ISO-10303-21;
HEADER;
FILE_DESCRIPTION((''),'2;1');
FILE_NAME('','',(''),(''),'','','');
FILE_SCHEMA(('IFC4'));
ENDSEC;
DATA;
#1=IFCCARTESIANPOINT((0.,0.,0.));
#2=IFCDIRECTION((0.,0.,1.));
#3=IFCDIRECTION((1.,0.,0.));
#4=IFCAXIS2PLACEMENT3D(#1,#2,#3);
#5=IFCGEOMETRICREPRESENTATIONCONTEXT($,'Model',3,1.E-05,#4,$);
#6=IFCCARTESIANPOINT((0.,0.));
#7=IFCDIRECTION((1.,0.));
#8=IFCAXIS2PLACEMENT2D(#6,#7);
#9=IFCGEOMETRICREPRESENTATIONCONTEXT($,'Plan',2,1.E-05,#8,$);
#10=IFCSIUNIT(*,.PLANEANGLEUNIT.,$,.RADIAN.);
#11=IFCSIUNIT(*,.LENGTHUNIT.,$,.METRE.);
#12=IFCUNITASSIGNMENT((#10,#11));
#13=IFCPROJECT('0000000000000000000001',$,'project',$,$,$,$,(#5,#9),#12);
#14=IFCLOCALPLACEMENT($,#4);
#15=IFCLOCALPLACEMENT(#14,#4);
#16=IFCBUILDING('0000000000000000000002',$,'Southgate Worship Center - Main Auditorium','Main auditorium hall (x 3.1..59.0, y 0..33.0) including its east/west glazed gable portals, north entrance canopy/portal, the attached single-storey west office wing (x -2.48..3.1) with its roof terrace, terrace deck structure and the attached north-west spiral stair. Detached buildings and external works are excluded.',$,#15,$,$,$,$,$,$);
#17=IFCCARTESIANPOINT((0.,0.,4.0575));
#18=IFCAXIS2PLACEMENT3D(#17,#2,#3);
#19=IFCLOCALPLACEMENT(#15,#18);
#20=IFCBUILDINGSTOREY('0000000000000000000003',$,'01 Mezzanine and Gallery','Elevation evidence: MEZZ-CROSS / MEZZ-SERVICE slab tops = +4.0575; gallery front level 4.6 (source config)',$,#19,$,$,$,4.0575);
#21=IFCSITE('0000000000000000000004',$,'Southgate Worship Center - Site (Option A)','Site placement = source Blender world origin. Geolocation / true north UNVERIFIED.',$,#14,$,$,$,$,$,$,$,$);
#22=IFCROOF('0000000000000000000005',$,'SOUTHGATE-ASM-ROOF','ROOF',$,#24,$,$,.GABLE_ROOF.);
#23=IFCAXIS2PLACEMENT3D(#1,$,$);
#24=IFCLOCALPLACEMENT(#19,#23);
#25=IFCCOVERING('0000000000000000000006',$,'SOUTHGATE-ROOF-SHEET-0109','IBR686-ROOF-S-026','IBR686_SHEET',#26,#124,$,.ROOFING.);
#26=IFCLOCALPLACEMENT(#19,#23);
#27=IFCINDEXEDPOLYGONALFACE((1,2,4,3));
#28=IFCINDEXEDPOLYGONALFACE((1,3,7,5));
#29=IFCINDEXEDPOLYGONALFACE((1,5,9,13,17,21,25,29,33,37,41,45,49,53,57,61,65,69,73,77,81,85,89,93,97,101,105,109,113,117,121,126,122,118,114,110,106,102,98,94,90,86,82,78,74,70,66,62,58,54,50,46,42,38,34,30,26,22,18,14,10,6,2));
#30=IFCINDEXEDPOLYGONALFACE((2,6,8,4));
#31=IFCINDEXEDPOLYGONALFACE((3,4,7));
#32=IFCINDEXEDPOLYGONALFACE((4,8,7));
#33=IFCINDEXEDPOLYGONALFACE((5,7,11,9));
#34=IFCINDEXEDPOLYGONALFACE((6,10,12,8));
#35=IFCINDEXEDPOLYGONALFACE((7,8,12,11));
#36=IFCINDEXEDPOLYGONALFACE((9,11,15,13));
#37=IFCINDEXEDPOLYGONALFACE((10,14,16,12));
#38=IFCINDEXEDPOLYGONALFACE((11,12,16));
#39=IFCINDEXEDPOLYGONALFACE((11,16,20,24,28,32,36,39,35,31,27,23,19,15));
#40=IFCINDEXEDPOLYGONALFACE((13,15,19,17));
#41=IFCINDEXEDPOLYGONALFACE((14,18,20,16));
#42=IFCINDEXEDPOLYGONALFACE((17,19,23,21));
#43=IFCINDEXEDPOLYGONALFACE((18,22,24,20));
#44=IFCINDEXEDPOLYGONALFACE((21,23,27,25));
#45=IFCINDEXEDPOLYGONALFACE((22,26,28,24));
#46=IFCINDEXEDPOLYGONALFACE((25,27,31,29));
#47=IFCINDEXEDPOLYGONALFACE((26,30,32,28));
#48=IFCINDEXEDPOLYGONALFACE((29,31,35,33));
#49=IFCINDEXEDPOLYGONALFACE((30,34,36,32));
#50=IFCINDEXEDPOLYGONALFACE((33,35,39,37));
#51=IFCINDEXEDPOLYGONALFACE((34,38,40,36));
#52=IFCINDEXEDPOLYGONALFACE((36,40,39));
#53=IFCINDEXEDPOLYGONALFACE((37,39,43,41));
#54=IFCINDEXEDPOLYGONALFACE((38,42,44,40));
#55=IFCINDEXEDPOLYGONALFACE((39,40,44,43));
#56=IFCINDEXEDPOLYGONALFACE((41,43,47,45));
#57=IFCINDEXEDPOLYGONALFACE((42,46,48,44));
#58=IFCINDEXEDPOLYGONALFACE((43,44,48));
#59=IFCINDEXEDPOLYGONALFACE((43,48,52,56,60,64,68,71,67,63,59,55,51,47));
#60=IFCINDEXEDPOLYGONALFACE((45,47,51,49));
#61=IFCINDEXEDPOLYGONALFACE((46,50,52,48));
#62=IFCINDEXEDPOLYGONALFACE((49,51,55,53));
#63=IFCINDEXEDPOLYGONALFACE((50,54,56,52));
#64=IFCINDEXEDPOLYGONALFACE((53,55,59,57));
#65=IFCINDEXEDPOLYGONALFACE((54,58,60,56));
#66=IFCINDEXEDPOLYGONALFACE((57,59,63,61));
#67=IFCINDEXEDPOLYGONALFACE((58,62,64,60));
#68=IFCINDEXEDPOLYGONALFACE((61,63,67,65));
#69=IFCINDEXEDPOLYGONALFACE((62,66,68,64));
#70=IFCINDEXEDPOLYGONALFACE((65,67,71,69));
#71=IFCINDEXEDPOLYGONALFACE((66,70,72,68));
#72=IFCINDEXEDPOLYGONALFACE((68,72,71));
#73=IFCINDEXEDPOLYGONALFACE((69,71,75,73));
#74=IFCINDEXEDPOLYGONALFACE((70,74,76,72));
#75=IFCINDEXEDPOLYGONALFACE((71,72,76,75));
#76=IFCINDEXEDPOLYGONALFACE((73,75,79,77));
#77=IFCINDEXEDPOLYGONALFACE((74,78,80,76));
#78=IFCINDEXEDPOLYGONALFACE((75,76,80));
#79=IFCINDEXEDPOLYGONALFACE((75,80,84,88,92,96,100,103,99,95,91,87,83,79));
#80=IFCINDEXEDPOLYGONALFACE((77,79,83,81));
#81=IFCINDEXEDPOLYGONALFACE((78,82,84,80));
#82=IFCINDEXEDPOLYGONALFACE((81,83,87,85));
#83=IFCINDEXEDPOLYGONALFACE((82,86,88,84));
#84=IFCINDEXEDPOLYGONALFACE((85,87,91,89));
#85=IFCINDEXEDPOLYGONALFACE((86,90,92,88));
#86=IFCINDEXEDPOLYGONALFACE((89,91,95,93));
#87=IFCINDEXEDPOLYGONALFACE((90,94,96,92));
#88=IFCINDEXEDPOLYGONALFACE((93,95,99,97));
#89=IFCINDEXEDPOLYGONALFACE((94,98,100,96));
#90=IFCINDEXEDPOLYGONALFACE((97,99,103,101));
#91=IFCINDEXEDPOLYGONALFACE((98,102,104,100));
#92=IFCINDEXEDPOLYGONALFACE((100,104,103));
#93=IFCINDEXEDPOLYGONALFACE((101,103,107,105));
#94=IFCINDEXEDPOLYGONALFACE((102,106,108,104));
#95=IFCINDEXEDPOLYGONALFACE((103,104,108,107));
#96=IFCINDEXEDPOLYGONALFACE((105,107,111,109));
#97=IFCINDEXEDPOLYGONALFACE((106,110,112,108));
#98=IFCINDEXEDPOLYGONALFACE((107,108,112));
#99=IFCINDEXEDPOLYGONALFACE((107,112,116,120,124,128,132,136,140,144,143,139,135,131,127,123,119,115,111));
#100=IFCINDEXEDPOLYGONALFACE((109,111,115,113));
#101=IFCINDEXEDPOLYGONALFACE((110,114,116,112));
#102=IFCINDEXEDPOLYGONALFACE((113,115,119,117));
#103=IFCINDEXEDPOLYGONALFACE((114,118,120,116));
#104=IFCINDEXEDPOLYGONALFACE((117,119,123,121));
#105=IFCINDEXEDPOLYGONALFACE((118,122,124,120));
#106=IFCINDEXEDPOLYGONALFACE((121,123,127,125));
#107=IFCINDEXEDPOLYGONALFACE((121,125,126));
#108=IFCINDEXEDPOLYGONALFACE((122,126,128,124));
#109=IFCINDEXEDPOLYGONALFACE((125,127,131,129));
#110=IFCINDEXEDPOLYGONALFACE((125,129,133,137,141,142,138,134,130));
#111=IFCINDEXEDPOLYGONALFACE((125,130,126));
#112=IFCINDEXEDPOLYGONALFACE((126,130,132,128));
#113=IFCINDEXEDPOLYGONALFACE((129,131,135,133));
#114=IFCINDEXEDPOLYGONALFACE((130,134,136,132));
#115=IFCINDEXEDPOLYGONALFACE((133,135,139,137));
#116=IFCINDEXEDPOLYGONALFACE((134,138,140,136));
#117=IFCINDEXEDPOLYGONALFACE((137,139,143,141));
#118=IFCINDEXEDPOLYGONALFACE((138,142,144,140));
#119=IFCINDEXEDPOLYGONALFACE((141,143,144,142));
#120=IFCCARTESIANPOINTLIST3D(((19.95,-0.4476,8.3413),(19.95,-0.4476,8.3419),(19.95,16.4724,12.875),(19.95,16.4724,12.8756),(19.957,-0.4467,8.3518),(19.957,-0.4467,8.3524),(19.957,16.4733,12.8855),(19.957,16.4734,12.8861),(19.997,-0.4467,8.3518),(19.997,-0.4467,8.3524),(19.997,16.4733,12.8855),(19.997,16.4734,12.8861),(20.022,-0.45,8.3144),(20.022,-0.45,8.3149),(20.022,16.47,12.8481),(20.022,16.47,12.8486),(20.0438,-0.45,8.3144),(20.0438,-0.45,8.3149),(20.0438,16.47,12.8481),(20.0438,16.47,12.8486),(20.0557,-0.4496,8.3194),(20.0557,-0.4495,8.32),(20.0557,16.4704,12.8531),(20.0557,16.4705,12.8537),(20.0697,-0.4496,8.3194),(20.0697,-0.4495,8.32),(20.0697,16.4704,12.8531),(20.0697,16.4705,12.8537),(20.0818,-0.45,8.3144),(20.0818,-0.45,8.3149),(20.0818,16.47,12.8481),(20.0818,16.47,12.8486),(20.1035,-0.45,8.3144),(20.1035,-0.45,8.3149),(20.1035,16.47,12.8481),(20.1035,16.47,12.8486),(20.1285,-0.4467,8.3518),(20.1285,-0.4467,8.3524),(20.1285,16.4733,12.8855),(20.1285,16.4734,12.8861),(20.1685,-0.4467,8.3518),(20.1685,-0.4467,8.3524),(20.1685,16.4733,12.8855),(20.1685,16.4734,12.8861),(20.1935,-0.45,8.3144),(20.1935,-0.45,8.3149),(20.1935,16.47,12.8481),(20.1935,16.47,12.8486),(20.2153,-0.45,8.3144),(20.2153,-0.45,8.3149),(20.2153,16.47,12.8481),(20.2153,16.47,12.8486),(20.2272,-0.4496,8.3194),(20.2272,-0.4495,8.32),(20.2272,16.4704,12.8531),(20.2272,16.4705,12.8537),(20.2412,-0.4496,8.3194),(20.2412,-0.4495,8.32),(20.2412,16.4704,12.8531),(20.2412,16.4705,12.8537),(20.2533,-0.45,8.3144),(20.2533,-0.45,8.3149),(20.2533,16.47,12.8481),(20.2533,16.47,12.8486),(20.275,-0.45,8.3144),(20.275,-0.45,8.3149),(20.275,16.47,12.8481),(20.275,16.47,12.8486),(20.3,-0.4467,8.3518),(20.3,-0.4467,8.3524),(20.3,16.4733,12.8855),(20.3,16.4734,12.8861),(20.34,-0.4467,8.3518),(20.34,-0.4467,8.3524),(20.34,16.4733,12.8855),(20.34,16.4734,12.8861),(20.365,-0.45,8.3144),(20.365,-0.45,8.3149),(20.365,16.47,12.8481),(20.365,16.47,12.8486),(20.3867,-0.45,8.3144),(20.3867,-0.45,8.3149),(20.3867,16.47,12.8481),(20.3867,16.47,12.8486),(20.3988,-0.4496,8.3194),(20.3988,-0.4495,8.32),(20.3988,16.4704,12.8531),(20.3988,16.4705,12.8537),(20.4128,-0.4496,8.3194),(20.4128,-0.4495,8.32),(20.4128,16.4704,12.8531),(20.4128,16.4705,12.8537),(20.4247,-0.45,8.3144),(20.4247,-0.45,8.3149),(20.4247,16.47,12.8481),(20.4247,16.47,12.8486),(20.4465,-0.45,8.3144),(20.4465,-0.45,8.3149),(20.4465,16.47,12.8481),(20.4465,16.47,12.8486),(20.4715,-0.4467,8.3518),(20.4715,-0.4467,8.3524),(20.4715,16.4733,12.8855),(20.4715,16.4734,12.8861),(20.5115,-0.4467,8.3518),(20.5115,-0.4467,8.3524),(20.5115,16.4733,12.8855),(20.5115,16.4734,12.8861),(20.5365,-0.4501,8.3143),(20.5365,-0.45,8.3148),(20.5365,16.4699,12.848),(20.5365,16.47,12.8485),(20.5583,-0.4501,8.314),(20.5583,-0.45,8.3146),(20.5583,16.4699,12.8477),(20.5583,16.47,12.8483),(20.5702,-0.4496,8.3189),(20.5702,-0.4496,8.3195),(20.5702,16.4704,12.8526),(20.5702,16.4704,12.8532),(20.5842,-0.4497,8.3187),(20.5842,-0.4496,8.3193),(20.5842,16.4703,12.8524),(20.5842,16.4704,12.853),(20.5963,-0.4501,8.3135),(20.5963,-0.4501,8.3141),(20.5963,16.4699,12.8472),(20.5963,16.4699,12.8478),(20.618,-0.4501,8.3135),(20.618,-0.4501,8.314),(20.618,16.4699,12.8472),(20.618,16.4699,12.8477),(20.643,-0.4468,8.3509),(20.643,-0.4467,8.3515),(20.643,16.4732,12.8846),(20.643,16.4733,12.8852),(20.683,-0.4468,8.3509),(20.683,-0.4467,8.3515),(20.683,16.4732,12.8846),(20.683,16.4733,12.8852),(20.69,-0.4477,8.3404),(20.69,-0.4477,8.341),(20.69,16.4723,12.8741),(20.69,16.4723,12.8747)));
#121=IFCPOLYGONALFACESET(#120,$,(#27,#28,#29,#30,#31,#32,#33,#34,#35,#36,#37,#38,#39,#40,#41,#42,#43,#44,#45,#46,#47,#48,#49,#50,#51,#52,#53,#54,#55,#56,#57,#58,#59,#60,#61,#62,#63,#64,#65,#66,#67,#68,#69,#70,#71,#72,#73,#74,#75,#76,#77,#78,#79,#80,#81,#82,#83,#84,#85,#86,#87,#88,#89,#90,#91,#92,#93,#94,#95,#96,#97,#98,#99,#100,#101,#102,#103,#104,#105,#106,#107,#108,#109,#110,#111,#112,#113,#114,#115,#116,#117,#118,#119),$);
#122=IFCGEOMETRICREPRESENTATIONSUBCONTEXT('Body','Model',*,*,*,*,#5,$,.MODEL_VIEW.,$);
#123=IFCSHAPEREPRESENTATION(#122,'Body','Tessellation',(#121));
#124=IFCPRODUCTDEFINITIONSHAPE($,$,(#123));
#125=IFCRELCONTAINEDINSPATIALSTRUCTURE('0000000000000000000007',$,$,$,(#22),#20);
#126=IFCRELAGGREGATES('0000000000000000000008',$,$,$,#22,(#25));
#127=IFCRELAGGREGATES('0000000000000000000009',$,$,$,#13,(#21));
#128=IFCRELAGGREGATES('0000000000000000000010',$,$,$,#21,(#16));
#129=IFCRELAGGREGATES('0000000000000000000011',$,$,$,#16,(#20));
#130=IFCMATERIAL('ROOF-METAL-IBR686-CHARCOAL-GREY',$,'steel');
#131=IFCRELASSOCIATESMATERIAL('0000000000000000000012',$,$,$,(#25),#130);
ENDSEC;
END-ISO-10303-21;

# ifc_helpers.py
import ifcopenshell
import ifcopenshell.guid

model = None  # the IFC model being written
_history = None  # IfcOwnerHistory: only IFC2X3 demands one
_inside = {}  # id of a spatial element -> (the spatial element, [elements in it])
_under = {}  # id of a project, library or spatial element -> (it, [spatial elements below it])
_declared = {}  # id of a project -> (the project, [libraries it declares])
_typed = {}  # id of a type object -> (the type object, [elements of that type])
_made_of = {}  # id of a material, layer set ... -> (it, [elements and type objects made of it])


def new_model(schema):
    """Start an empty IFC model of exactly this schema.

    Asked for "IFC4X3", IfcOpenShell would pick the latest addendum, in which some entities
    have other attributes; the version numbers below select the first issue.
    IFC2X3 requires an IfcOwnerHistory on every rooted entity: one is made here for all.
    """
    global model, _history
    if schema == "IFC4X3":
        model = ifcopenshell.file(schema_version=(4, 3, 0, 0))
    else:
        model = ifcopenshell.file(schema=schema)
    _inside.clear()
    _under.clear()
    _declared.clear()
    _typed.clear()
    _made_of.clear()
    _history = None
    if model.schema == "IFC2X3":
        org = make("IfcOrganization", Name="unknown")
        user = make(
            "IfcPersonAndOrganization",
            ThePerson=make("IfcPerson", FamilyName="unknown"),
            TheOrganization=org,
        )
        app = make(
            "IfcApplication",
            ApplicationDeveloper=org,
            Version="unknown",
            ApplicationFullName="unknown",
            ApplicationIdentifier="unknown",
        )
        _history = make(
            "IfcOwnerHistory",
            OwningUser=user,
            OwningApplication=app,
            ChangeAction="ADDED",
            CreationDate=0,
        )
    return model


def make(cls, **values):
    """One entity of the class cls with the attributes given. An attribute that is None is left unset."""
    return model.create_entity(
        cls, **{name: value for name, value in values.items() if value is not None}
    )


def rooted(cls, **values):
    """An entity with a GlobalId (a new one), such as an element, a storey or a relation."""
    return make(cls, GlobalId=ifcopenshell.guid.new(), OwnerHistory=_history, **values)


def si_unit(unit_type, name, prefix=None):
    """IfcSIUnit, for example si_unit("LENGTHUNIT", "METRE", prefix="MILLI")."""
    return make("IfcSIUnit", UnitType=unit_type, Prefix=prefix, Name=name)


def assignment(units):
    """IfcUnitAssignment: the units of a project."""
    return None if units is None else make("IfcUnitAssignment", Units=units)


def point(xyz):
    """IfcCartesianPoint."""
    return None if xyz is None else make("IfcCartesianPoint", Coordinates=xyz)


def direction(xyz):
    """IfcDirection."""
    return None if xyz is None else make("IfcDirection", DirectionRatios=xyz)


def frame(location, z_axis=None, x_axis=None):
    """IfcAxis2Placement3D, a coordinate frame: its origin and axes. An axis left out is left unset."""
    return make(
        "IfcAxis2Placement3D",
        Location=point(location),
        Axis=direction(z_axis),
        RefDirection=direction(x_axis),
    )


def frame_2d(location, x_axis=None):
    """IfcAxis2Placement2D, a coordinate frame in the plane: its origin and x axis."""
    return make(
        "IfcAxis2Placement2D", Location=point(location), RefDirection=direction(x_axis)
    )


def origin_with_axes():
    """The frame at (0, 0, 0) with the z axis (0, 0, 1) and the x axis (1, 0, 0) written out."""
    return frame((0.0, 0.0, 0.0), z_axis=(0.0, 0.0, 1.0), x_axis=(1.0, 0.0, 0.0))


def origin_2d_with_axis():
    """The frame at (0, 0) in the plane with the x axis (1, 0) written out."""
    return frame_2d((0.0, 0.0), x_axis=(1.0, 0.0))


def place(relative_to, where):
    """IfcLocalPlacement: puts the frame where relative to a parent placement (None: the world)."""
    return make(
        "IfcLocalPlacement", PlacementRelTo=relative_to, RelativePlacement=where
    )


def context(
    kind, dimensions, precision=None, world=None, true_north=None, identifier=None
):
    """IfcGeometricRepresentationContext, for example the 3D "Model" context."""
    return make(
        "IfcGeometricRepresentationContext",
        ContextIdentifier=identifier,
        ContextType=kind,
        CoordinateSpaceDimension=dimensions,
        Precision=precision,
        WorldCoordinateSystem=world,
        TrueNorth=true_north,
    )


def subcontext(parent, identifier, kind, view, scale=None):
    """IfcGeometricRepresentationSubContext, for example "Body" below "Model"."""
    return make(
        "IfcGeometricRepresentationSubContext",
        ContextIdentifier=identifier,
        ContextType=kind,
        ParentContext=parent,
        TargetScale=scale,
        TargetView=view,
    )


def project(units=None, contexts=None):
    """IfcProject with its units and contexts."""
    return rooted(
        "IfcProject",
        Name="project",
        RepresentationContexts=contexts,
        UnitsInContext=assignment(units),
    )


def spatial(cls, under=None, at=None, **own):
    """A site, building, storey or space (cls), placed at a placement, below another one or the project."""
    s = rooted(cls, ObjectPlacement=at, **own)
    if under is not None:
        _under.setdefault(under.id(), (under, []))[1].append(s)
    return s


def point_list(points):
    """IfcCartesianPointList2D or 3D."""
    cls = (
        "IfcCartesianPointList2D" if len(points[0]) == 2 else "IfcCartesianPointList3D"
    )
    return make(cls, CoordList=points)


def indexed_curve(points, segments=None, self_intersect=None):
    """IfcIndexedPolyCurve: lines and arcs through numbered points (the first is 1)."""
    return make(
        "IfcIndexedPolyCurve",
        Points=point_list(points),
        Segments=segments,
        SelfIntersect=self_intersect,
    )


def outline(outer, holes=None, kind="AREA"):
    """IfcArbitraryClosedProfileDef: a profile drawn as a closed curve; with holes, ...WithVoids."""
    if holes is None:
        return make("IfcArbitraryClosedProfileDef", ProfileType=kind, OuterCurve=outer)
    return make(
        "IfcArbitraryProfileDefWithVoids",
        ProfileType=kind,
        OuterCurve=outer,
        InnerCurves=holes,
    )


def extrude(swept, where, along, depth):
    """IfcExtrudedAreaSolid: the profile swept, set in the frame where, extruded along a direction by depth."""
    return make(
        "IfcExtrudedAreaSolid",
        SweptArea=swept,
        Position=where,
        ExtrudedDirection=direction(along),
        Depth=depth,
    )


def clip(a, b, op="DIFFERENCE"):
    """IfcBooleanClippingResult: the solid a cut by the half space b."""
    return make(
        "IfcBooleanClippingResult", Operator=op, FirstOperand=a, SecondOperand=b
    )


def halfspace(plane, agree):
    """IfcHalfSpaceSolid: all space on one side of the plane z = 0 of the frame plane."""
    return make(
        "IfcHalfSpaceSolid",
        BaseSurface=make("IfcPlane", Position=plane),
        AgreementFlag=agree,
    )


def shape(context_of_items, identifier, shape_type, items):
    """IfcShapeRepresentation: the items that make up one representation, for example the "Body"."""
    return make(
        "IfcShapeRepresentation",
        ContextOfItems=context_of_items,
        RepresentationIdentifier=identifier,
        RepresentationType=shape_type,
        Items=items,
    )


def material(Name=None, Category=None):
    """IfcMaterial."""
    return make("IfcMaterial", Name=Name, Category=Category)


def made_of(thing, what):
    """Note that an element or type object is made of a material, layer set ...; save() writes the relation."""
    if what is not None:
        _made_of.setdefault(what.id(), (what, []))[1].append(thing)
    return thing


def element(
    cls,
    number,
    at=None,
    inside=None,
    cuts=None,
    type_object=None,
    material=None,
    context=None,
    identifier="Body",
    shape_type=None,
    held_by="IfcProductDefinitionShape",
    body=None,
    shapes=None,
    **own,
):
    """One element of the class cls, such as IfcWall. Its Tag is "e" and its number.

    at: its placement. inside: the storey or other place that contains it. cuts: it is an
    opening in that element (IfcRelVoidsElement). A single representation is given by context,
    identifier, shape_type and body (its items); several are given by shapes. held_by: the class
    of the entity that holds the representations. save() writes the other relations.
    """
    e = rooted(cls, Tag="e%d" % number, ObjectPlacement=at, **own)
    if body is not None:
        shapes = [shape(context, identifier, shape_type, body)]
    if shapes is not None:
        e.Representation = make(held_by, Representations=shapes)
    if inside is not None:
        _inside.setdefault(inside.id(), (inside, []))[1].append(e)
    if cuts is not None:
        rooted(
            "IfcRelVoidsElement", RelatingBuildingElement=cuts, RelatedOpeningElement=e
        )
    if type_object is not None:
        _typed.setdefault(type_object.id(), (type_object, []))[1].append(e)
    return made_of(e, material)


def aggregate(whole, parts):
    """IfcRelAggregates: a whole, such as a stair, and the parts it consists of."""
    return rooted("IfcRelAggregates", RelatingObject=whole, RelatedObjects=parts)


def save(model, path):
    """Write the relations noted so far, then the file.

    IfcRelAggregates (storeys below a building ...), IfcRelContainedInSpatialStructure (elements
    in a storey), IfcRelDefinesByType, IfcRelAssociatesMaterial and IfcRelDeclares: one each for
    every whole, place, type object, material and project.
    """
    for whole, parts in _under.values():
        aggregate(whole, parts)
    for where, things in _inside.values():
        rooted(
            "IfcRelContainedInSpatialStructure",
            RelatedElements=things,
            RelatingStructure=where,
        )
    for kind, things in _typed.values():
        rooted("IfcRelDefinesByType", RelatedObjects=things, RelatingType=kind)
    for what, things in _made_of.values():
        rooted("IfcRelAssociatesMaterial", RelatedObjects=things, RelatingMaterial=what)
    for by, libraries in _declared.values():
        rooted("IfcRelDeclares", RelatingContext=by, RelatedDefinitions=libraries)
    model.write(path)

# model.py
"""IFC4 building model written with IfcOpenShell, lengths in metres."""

from ifc_helpers import new_model, si_unit, frame, origin_with_axes, origin_2d_with_axis, place, context, subcontext, project, spatial, indexed_curve, outline, extrude, clip, halfspace, material, element, aggregate, save


model = new_model("IFC4")

# Units and contexts
model_context = context("Model", 3, precision=1e-05, world=origin_with_axes())
plan_context = context("Plan", 2, precision=1e-05, world=origin_2d_with_axis())
body_context = subcontext(model_context, "Body", "Model", "MODEL_VIEW")
ifc_project = project(units=[si_unit("PLANEANGLEUNIT", "RADIAN"), si_unit("LENGTHUNIT", "METRE")], contexts=[model_context, plan_context])

# Site, building, storey
site_placement = place(None, origin_with_axes())
site = spatial("IfcSite", under=ifc_project, at=site_placement, Name="Southgate Worship Center - Site (Option A)", Description="Site placement = source Blender world origin. Geolocation / true north UNVERIFIED.")
building_placement = place(site_placement, origin_with_axes())
building = spatial("IfcBuilding", under=site, at=building_placement, Name="Southgate Worship Center - Main Auditorium", Description="Main auditorium hall (x 3.1..59.0, y 0..33.0) including its east/west glazed gable portals, north entrance canopy/portal, the attached single-storey west office wing (x -2.48..3.1) with its roof terrace, terrace deck structure and the attached north-west spiral stair. Detached buildings and external works are excluded.")
storey_placement = place(building_placement, frame((0.0, 0.0, 4.0575), z_axis=(0.0, 0.0, 1.0), x_axis=(1.0, 0.0, 0.0)))
storey = spatial("IfcBuildingStorey", under=building, at=storey_placement, Name="01 Mezzanine and Gallery", Description="Elevation evidence: MEZZ-CROSS / MEZZ-SERVICE slab tops = +4.0575; gallery front level 4.6 (source config)", Elevation=4.0575)

# Roof, covering
roof_placement = place(storey_placement, origin_with_axes())
roof = element("IfcRoof", 1, at=roof_placement, inside=storey, Name="SOUTHGATE-ASM-ROOF", Description="ROOF", PredefinedType="GABLE_ROOF")
ifc_material_1 = material(Name="ROOF-METAL-IBR686-CHARCOAL-GREY", Category="steel")
covering_1_placement = place(roof_placement, frame((19.95, -0.4501, 8.3135), z_axis=(0.0, 0.0, 1.0), x_axis=(1.0, 0.0, 0.0)))
covering_1 = element("IfcCovering", 2, at=covering_1_placement, material=ifc_material_1, Name="SOUTHGATE-ROOF-SHEET-0109", Description="IBR686-ROOF-S-026", ObjectType="IBR686_SHEET", PredefinedType="ROOFING", context=body_context, shape_type="Clipping", body=[
    clip(clip(extrude(outline(indexed_curve([(0.0, 0.0), (0.025, 0.0353), (0.065, 0.0353), (0.072, 0.0254), (0.072, 0.0259), (0.065, 0.0358), (0.025, 0.0358), (0.0, 0.0005), (-0.0218, 0.0005), (-0.0338, 0.0053), (-0.0478, 0.0053), (-0.0598, 0.0005), (-0.0815, 0.0005), (-0.1065, 0.0358), (-0.1465, 0.0358), (-0.1715, 0.0005), (-0.1933, 0.0005), (-0.2052, 0.0053), (-0.2192, 0.0053), (-0.2313, 0.0005), (-0.253, 0.0005), (-0.278, 0.0358), (-0.318, 0.0358), (-0.343, 0.0005), (-0.3647, 0.0005), (-0.3768, 0.0053), (-0.3908, 0.0053), (-0.4028, 0.0005), (-0.4245, 0.0005), (-0.4495, 0.0358), (-0.4895, 0.0358), (-0.5145, 0.0004), (-0.5363, 0.0002), (-0.5483, 0.0048), (-0.5623, 0.0046), (-0.5743, -0.0003), (-0.596, -0.0004), (-0.621, 0.0349), (-0.661, 0.0349), (-0.668, 0.0251), (-0.668, 0.0246), (-0.661, 0.0344), (-0.621, 0.0344), (-0.596, -0.0009), (-0.5743, -0.0008), (-0.5623, 0.0041), (-0.5483, 0.0043), (-0.5363, -0.0003), (-0.5145, -0.0001), (-0.4895, 0.0353), (-0.4495, 0.0353), (-0.4245, 0.0), (-0.4028, 0.0), (-0.3908, 0.0048), (-0.3768, 0.0048), (-0.3647, 0.0), (-0.343, 0.0), (-0.318, 0.0353), (-0.278, 0.0353), (-0.253, 0.0), (-0.2313, 0.0), (-0.2192, 0.0048), (-0.2052, 0.0048), (-0.1933, 0.0), (-0.1715, 0.0), (-0.1465, 0.0353), (-0.1065, 0.0353), (-0.0815, 0.0), (-0.0598, 0.0), (-0.0478, 0.0048), (-0.0338, 0.0048), (-0.0218, 0.0), (0.0, 0.0)], self_intersect=False)), frame((0.072, -0.0003, 0.0008), z_axis=(0.0, 0.965926, 0.258819), x_axis=(-1.0, 0.0, 0.0)), (0.0, 0.0, 1.0), 17.5303), halfspace(frame((0.37, 0.0012, 0.014), z_axis=(0.0, -0.996022, 0.089113), x_axis=(1.0, 0.0, 0.0)), False)), halfspace(frame((0.37, 16.9212, 4.5477), z_axis=(0.0, 0.996021, -0.089119), x_axis=(-1.0, 0.0, 0.0)), False)),
])
aggregate(roof, [covering_1])

save(model, "model.ifc")
